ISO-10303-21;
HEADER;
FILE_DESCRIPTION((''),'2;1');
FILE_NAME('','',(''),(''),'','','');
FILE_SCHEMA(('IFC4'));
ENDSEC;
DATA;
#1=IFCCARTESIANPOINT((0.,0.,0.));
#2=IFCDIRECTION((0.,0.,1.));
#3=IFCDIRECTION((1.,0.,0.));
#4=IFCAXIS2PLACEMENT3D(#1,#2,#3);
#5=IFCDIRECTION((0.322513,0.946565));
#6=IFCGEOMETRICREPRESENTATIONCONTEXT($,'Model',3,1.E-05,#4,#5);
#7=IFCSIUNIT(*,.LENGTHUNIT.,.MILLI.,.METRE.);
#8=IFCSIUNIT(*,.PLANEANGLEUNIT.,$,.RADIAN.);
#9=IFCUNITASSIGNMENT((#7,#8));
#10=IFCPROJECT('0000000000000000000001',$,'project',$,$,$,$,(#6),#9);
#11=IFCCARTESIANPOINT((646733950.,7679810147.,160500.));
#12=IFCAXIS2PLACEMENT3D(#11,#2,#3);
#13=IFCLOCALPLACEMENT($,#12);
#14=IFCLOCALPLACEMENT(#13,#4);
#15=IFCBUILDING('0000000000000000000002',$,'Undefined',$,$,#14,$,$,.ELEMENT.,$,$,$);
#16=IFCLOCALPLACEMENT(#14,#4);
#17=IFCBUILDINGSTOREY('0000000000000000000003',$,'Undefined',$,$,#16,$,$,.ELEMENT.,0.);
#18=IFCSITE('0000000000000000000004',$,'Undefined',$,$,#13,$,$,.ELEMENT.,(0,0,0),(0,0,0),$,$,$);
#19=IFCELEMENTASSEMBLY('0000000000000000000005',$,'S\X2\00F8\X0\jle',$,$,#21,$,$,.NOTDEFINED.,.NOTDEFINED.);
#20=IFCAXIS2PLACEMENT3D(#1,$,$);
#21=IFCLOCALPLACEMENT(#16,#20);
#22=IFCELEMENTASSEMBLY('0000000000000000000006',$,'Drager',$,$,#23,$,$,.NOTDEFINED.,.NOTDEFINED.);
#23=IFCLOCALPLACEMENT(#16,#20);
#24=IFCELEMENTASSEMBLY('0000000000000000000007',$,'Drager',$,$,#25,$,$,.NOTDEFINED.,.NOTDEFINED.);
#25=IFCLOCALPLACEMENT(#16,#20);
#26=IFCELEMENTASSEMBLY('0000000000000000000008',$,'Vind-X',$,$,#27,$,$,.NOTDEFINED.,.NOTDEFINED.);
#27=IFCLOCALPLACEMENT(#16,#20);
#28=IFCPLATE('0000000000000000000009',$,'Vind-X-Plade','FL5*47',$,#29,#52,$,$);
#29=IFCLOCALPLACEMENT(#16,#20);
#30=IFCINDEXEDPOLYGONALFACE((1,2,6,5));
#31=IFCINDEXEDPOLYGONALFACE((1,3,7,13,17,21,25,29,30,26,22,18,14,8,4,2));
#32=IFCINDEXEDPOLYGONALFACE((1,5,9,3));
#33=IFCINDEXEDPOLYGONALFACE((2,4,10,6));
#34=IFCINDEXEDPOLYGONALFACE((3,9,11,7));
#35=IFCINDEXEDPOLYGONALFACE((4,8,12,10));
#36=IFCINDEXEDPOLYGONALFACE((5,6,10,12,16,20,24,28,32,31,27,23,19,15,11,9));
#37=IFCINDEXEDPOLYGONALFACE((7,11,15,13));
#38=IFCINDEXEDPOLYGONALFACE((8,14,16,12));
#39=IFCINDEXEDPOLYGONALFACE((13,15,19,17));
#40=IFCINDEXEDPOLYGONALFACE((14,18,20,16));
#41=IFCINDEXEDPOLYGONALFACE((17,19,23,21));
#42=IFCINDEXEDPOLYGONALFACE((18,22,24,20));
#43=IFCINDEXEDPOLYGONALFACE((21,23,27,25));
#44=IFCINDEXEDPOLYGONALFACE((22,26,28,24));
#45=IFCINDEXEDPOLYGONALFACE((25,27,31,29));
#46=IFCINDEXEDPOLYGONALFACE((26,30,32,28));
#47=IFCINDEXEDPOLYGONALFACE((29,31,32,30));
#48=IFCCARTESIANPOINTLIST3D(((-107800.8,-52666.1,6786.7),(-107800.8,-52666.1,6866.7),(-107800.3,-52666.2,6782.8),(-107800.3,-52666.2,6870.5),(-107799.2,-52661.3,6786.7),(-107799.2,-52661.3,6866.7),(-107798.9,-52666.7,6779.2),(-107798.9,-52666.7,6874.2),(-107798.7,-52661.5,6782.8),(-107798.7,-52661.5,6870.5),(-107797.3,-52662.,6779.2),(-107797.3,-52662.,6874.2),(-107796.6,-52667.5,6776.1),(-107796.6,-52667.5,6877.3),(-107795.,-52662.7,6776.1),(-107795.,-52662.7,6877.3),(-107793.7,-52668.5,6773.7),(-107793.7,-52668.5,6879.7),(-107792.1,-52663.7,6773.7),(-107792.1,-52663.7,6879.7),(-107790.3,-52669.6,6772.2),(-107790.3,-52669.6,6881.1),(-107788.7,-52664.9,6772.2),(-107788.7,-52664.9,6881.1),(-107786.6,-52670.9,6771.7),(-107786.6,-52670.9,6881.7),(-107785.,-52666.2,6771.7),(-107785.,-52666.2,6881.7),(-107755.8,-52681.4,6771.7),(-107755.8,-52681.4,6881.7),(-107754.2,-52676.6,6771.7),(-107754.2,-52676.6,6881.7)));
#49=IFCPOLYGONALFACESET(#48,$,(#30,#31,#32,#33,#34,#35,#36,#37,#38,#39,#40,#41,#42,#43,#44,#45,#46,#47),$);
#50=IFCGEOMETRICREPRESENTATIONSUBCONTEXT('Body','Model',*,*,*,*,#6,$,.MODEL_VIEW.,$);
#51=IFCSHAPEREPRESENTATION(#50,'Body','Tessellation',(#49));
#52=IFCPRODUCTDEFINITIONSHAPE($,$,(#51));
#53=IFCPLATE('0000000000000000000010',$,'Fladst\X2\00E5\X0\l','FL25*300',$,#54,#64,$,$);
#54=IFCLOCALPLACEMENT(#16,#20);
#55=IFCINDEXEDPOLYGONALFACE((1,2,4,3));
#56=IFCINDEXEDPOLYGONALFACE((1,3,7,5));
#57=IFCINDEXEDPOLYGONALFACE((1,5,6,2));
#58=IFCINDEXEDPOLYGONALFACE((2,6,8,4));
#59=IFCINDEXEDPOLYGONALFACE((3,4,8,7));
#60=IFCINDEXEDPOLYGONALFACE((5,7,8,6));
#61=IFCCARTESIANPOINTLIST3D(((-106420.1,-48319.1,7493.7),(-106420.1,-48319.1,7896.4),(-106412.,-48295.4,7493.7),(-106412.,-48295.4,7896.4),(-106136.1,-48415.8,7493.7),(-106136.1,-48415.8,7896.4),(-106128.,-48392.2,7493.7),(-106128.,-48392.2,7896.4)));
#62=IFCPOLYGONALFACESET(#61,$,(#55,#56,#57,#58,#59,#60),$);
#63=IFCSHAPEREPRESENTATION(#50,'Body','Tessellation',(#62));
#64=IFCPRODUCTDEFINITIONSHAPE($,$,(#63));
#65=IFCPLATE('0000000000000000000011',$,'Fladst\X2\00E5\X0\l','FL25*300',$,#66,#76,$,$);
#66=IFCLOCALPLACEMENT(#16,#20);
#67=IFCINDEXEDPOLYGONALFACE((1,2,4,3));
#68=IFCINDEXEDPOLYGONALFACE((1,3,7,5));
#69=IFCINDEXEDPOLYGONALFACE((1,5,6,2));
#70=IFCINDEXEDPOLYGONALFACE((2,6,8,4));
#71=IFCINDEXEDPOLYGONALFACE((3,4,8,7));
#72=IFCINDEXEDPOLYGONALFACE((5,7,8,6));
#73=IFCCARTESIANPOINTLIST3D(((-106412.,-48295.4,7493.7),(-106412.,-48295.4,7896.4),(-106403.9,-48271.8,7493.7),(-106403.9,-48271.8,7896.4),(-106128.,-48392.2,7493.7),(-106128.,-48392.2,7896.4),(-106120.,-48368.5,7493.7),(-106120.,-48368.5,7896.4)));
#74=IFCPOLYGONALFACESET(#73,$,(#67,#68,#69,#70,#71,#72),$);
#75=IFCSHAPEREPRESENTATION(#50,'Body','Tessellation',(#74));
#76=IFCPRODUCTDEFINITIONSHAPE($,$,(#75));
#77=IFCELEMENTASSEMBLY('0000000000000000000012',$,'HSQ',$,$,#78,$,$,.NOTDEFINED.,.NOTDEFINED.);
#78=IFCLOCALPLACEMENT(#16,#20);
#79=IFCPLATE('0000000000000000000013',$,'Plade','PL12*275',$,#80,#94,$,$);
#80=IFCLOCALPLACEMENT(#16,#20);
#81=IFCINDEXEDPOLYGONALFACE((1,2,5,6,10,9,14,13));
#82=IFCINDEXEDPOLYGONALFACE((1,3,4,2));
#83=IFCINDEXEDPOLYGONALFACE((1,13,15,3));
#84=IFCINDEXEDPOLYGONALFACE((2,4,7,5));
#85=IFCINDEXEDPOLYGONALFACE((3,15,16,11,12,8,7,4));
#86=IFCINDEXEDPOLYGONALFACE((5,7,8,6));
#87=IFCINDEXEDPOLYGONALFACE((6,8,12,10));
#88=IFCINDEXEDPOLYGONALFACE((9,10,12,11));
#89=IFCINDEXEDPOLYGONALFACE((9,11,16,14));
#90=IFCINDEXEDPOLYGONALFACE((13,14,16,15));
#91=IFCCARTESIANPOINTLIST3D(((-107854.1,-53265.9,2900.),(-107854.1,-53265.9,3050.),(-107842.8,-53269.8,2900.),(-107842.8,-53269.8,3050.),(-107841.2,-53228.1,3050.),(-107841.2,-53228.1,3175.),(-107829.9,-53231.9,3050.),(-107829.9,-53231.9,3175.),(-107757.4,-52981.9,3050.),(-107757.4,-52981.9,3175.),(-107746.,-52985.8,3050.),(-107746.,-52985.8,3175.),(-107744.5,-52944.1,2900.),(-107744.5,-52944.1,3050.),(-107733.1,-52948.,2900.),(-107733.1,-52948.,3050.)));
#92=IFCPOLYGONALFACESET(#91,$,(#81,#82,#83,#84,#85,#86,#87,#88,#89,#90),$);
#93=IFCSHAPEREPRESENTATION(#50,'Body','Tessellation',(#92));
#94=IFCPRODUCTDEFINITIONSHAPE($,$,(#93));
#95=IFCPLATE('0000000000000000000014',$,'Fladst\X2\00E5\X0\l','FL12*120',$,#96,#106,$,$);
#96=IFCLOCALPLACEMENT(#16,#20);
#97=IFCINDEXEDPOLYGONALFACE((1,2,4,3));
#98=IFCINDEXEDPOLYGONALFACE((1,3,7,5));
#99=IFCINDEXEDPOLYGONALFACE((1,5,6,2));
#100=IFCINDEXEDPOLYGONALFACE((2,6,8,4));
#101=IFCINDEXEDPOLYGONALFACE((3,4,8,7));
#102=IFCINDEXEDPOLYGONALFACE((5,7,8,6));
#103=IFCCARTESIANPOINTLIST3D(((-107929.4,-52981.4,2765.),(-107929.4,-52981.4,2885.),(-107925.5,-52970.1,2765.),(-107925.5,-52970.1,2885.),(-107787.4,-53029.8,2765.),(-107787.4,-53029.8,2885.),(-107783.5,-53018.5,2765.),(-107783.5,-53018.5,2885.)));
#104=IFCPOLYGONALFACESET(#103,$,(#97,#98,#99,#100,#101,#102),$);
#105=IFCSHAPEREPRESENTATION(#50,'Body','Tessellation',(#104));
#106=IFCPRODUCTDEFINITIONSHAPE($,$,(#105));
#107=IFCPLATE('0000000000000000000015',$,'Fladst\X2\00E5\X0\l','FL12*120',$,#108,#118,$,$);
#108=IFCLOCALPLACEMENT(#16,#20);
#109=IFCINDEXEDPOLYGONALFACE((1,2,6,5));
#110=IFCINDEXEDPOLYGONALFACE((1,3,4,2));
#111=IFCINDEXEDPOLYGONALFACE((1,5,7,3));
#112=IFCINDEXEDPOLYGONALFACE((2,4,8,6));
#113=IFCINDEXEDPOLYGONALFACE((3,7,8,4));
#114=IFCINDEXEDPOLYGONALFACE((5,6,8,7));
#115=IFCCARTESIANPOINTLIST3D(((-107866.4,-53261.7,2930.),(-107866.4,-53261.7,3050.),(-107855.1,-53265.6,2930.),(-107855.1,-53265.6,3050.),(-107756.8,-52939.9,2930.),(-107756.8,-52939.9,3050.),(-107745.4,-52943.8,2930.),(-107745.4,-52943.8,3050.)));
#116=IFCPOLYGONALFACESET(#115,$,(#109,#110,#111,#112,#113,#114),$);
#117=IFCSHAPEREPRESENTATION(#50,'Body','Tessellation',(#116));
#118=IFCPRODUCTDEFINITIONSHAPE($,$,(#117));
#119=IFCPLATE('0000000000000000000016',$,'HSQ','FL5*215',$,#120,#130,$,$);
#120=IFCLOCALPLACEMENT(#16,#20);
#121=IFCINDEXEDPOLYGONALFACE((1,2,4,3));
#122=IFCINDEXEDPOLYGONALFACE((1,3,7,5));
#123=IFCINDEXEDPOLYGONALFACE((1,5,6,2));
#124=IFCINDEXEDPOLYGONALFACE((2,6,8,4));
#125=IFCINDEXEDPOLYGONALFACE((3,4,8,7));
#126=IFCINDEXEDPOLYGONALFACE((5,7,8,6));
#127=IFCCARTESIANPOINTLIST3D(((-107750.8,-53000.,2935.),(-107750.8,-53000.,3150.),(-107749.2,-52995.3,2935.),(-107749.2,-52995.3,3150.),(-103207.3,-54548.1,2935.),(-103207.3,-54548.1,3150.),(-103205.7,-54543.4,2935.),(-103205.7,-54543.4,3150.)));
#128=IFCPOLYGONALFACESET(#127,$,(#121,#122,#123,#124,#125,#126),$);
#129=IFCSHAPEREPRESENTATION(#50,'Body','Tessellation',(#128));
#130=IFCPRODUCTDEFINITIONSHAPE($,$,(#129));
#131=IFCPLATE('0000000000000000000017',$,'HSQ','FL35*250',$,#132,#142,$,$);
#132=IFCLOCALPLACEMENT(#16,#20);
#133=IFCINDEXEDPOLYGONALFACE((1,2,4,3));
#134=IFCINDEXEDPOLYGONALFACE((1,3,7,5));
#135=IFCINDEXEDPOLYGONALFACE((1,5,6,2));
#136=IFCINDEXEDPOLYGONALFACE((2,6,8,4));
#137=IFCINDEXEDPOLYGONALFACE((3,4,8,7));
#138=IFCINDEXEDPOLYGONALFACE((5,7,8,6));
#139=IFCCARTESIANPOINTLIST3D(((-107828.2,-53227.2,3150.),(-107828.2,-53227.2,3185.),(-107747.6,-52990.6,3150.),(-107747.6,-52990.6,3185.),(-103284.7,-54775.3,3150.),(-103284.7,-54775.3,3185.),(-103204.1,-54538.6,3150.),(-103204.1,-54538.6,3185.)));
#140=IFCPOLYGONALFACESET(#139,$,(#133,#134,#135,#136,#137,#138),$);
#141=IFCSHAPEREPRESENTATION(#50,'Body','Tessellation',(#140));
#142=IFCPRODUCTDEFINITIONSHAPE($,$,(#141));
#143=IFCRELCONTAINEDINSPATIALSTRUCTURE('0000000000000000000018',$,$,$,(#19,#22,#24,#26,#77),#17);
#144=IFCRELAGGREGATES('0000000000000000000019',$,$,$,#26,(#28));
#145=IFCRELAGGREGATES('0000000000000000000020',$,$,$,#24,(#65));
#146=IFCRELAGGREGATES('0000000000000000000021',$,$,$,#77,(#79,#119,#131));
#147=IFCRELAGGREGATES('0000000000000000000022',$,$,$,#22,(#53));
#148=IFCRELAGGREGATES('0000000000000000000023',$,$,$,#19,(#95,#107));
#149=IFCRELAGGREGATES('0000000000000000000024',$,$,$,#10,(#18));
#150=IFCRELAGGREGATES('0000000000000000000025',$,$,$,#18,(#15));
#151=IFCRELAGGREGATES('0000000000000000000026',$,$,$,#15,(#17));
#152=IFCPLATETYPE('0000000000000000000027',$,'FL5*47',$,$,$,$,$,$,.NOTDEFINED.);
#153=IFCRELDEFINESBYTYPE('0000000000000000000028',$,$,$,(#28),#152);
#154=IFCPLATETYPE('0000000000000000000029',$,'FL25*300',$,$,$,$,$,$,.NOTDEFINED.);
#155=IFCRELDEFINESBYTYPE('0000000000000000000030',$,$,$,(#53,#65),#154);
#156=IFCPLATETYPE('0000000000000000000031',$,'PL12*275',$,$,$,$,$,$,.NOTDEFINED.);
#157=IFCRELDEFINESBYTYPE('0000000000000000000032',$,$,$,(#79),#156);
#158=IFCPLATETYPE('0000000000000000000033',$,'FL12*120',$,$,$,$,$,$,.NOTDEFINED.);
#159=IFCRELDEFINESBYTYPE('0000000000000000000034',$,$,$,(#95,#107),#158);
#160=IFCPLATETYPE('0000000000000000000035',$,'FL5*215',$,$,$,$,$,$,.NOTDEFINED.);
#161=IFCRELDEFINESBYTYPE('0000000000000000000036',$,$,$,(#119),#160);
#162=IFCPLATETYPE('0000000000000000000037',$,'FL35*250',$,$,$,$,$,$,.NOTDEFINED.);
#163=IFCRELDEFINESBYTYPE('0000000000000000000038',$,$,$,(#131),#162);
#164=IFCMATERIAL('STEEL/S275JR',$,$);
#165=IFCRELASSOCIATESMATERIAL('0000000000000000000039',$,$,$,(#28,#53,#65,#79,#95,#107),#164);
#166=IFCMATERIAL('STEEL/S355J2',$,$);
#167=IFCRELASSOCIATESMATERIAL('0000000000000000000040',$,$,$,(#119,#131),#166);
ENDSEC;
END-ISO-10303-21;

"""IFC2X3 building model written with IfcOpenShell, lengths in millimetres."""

from ifc_helpers import new_model, si_unit, direction, frame, frame_2d, origin_with_axes, place, context, subcontext, project, spatial, polyline, circle_curve, parameter, trimmed, segment, composite_curve, outline, extrude, material, type_object, element, aggregate, save


model = new_model("IFC2X3")

# Units and contexts
model_context = context("Model", 3, precision=1e-05, world=origin_with_axes(), true_north=direction((0.322513, 0.946565)))
body_context = subcontext(model_context, "Body", "Model", "MODEL_VIEW")
ifc_project = project(units=[si_unit("LENGTHUNIT", "METRE", prefix="MILLI"), si_unit("PLANEANGLEUNIT", "RADIAN")], contexts=[model_context])

# Site, building, storey
site_placement = place(None, frame((646733950.0, 7679810147.0, 160500.0), z_axis=(0.0, 0.0, 1.0), x_axis=(1.0, 0.0, 0.0)))
site = spatial("IfcSite", under=ifc_project, at=site_placement, Name="Undefined", CompositionType="ELEMENT", RefLatitude=(0, 0, 0), RefLongitude=(0, 0, 0))
building_placement = place(site_placement, origin_with_axes())
building = spatial("IfcBuilding", under=site, at=building_placement, Name="Undefined", CompositionType="ELEMENT")
storey_placement = place(building_placement, origin_with_axes())
storey = spatial("IfcBuildingStorey", under=building, at=storey_placement, Name="Undefined", CompositionType="ELEMENT", Elevation=0.0)

# Element assemblies
assembly_1_placement = place(storey_placement, origin_with_axes())
assembly_1 = element("IfcElementAssembly", 1, at=assembly_1_placement, inside=storey, Name="Søjle", AssemblyPlace="NOTDEFINED", PredefinedType="NOTDEFINED")
ifc_material_1 = material(Name="STEEL/S275JR")
assembly_2_placement = place(storey_placement, origin_with_axes())
assembly_2 = element("IfcElementAssembly", 2, at=assembly_2_placement, inside=storey, Name="Drager", AssemblyPlace="NOTDEFINED", PredefinedType="NOTDEFINED")
ifc_material_2 = material(Name="STEEL/S355J2")
assembly_3_placement = place(storey_placement, origin_with_axes())
assembly_3 = element("IfcElementAssembly", 3, at=assembly_3_placement, inside=storey, Name="Drager", AssemblyPlace="NOTDEFINED", PredefinedType="NOTDEFINED")

# Element assembly
assembly_4_placement = place(storey_placement, origin_with_axes())
assembly_4 = element("IfcElementAssembly", 4, at=assembly_4_placement, inside=storey, Name="Vind-X", AssemblyPlace="NOTDEFINED", PredefinedType="NOTDEFINED")

# Plates
plate_type_1 = type_object("IfcPlateType", Name="FL5*47", PredefinedType="NOTDEFINED")
plate_1_placement = place(assembly_4_placement, frame((-107755.0, -52679.0, 6771.7), z_axis=(0.322513, 0.946565, 0.0), x_axis=(-0.946565, 0.322513, 0.0)))
plate_1 = element("IfcPlate", 5, at=plate_1_placement, type_object=plate_type_1, material=ifc_material_1, Name="Vind-X-Plade", Description="FL5*47", context=body_context, shape_type="SweptSolid", body=[
    extrude(outline(composite_curve([segment(polyline([(0.0, 0.0), (32.5, 0.0)]), True, "CONTINUOUS"), segment(trimmed(circle_curve(frame_2d((32.5, 15.0), x_axis=(0.0, -1.0)), 15.0), [parameter(0.0)], [parameter(1.570796)], True, "PARAMETER"), True, "CONTINUOUS"), segment(polyline([(47.5, 15.0), (47.5, 95.0)]), True, "CONTINUOUS"), segment(trimmed(circle_curve(frame_2d((32.5, 95.0), x_axis=(1.0, 0.0)), 15.0), [parameter(0.0)], [parameter(1.570796)], True, "PARAMETER"), True, "CONTINUOUS"), segment(polyline([(32.5, 110.0), (0.0, 110.0), (0.0, 0.0)]), True, "CONTINUOUS")], self_intersect=True)), frame((0.0, 0.0, -2.5), z_axis=(0.0, 0.0, 1.0), x_axis=(1.0, 0.0, 0.0)), (0.0, 0.0, 1.0), 5.0),
])
aggregate(assembly_4, [plate_1])
plate_type_2 = type_object("IfcPlateType", Name="FL25*300", PredefinedType="NOTDEFINED")
plate_2_placement = place(assembly_2_placement, frame((-106274.1, -48355.6, 7493.7), z_axis=(-0.322513, -0.946565, 0.0), x_axis=(0.0, 0.0, 1.0)))
plate_2 = element("IfcPlate", 6, at=plate_2_placement, type_object=plate_type_2, material=ifc_material_1, Name="Fladstål", Description="FL25*300", context=body_context, shape_type="SweptSolid", body=[
    extrude(outline(polyline([(0.0, -150.0), (0.0, 150.0), (402.7, 150.0), (402.7, -150.0), (0.0, -150.0)])), frame((0.0, 0.0, -12.5), z_axis=(0.0, 0.0, 1.0), x_axis=(1.0, 0.0, 0.0)), (0.0, 0.0, 1.0), 25.0),
])
plate_3_placement = place(assembly_3_placement, frame((-106266.0, -48332.0, 7493.7), z_axis=(-0.322513, -0.946565, 0.0), x_axis=(0.0, 0.0, 1.0)))
plate_3 = element("IfcPlate", 7, at=plate_3_placement, type_object=plate_type_2, material=ifc_material_1, Name="Fladstål", Description="FL25*300", context=body_context, shape_type="SweptSolid", body=[
    extrude(outline(polyline([(0.0, -150.0), (0.0, 150.0), (402.7, 150.0), (402.7, -150.0), (0.0, -150.0)])), frame((0.0, 0.0, -12.5), z_axis=(0.0, 0.0, 1.0), x_axis=(1.0, 0.0, 0.0)), (0.0, 0.0, 1.0), 25.0),
])
aggregate(assembly_3, [plate_3])

# Element assembly, plate
assembly_5_placement = place(storey_placement, origin_with_axes())
assembly_5 = element("IfcElementAssembly", 8, at=assembly_5_placement, inside=storey, Name="HSQ", AssemblyPlace="NOTDEFINED", PredefinedType="NOTDEFINED")
plate_type_3 = type_object("IfcPlateType", Name="PL12*275", PredefinedType="NOTDEFINED")
plate_4_placement = place(assembly_5_placement, frame((-107738.8, -52946.0, 3175.0), z_axis=(0.946565, -0.322513, 0.0), x_axis=(-0.322513, -0.946565, 0.0)))
plate_4 = element("IfcPlate", 9, at=plate_4_placement, type_object=plate_type_3, material=ifc_material_1, Name="Plade", Description="PL12*275", context=body_context, shape_type="SweptSolid", body=[
    extrude(outline(polyline([(0.0, 125.0), (40.0, 125.0), (40.0, 0.0), (300.0, 0.0), (300.0, 125.0), (340.0, 125.0), (340.0, 275.0), (0.0, 275.0), (0.0, 125.0)])), frame((0.0, 0.0, -6.0), z_axis=(0.0, 0.0, 1.0), x_axis=(1.0, 0.0, 0.0)), (0.0, 0.0, 1.0), 12.0),
])

# Plates
plate_type_4 = type_object("IfcPlateType", Name="FL12*120", PredefinedType="NOTDEFINED")
plate_5_placement = place(assembly_1_placement, frame((-107785.5, -53024.1, 2885.0), z_axis=(-0.322513, -0.946565, 0.0), x_axis=(-0.946565, 0.322513, 0.0)))
plate_5 = element("IfcPlate", 10, at=plate_5_placement, type_object=plate_type_4, material=ifc_material_1, Name="Fladstål", Description="FL12*120", context=body_context, shape_type="SweptSolid", body=[
    extrude(outline(polyline([(0.0, 0.0), (150.0, 0.0), (150.0, 120.0), (0.0, 120.0), (0.0, 0.0)])), frame((0.0, 0.0, -6.0), z_axis=(0.0, 0.0, 1.0), x_axis=(1.0, 0.0, 0.0)), (0.0, 0.0, 1.0), 12.0),
])
plate_6_placement = place(assembly_1_placement, frame((-107751.1, -52941.8, 3050.0), z_axis=(0.946565, -0.322513, 0.0), x_axis=(-0.322513, -0.946565, 0.0)))
plate_6 = element("IfcPlate", 11, at=plate_6_placement, type_object=plate_type_4, material=ifc_material_1, Name="Fladstål", Description="FL12*120", context=body_context, shape_type="SweptSolid", body=[
    extrude(outline(polyline([(0.0, 0.0), (340.0, 0.0), (340.0, 120.0), (0.0, 120.0), (0.0, 0.0)])), frame((0.0, 0.0, -6.0), z_axis=(0.0, 0.0, 1.0), x_axis=(1.0, 0.0, 0.0)), (0.0, 0.0, 1.0), 12.0),
])
plate_type_5 = type_object("IfcPlateType", Name="FL5*215", PredefinedType="NOTDEFINED")
plate_7_placement = place(assembly_5_placement, frame((-107750.0, -52997.7, 3042.5), z_axis=(-0.322513, -0.946565, 0.0), x_axis=(0.946565, -0.322513, 0.0)))
plate_7 = element("IfcPlate", 12, at=plate_7_placement, type_object=plate_type_5, material=ifc_material_2, Name="HSQ", Description="FL5*215", context=body_context, shape_type="SweptSolid", body=[
    extrude(outline(polyline([(0.0, -107.5), (0.0, 107.5), (4800.0, 107.5), (4800.0, -107.5), (0.0, -107.5)])), frame((0.0, 0.0, -2.5), z_axis=(0.0, 0.0, 1.0), x_axis=(1.0, 0.0, 0.0)), (0.0, 0.0, 1.0), 5.0),
])
plate_type_6 = type_object("IfcPlateType", Name="FL35*250", PredefinedType="NOTDEFINED")
plate_8_placement = place(assembly_5_placement, frame((-107787.9, -53108.9, 3167.5), z_axis=(0.0, 0.0, 1.0), x_axis=(0.946565, -0.322513, 0.0)))
plate_8 = element("IfcPlate", 13, at=plate_8_placement, type_object=plate_type_6, material=ifc_material_2, Name="HSQ", Description="FL35*250", context=body_context, shape_type="SweptSolid", body=[
    extrude(outline(polyline([(0.0, -125.0), (0.0, 125.0), (4800.0, 125.0), (4800.0, -125.0), (0.0, -125.0)])), frame((0.0, 0.0, -17.5), z_axis=(0.0, 0.0, 1.0), x_axis=(1.0, 0.0, 0.0)), (0.0, 0.0, 1.0), 35.0),
])
aggregate(assembly_5, [plate_4, plate_7, plate_8])

aggregate(assembly_2, [plate_2])
aggregate(assembly_1, [plate_5, plate_6])

save(model, "model.ifc")
